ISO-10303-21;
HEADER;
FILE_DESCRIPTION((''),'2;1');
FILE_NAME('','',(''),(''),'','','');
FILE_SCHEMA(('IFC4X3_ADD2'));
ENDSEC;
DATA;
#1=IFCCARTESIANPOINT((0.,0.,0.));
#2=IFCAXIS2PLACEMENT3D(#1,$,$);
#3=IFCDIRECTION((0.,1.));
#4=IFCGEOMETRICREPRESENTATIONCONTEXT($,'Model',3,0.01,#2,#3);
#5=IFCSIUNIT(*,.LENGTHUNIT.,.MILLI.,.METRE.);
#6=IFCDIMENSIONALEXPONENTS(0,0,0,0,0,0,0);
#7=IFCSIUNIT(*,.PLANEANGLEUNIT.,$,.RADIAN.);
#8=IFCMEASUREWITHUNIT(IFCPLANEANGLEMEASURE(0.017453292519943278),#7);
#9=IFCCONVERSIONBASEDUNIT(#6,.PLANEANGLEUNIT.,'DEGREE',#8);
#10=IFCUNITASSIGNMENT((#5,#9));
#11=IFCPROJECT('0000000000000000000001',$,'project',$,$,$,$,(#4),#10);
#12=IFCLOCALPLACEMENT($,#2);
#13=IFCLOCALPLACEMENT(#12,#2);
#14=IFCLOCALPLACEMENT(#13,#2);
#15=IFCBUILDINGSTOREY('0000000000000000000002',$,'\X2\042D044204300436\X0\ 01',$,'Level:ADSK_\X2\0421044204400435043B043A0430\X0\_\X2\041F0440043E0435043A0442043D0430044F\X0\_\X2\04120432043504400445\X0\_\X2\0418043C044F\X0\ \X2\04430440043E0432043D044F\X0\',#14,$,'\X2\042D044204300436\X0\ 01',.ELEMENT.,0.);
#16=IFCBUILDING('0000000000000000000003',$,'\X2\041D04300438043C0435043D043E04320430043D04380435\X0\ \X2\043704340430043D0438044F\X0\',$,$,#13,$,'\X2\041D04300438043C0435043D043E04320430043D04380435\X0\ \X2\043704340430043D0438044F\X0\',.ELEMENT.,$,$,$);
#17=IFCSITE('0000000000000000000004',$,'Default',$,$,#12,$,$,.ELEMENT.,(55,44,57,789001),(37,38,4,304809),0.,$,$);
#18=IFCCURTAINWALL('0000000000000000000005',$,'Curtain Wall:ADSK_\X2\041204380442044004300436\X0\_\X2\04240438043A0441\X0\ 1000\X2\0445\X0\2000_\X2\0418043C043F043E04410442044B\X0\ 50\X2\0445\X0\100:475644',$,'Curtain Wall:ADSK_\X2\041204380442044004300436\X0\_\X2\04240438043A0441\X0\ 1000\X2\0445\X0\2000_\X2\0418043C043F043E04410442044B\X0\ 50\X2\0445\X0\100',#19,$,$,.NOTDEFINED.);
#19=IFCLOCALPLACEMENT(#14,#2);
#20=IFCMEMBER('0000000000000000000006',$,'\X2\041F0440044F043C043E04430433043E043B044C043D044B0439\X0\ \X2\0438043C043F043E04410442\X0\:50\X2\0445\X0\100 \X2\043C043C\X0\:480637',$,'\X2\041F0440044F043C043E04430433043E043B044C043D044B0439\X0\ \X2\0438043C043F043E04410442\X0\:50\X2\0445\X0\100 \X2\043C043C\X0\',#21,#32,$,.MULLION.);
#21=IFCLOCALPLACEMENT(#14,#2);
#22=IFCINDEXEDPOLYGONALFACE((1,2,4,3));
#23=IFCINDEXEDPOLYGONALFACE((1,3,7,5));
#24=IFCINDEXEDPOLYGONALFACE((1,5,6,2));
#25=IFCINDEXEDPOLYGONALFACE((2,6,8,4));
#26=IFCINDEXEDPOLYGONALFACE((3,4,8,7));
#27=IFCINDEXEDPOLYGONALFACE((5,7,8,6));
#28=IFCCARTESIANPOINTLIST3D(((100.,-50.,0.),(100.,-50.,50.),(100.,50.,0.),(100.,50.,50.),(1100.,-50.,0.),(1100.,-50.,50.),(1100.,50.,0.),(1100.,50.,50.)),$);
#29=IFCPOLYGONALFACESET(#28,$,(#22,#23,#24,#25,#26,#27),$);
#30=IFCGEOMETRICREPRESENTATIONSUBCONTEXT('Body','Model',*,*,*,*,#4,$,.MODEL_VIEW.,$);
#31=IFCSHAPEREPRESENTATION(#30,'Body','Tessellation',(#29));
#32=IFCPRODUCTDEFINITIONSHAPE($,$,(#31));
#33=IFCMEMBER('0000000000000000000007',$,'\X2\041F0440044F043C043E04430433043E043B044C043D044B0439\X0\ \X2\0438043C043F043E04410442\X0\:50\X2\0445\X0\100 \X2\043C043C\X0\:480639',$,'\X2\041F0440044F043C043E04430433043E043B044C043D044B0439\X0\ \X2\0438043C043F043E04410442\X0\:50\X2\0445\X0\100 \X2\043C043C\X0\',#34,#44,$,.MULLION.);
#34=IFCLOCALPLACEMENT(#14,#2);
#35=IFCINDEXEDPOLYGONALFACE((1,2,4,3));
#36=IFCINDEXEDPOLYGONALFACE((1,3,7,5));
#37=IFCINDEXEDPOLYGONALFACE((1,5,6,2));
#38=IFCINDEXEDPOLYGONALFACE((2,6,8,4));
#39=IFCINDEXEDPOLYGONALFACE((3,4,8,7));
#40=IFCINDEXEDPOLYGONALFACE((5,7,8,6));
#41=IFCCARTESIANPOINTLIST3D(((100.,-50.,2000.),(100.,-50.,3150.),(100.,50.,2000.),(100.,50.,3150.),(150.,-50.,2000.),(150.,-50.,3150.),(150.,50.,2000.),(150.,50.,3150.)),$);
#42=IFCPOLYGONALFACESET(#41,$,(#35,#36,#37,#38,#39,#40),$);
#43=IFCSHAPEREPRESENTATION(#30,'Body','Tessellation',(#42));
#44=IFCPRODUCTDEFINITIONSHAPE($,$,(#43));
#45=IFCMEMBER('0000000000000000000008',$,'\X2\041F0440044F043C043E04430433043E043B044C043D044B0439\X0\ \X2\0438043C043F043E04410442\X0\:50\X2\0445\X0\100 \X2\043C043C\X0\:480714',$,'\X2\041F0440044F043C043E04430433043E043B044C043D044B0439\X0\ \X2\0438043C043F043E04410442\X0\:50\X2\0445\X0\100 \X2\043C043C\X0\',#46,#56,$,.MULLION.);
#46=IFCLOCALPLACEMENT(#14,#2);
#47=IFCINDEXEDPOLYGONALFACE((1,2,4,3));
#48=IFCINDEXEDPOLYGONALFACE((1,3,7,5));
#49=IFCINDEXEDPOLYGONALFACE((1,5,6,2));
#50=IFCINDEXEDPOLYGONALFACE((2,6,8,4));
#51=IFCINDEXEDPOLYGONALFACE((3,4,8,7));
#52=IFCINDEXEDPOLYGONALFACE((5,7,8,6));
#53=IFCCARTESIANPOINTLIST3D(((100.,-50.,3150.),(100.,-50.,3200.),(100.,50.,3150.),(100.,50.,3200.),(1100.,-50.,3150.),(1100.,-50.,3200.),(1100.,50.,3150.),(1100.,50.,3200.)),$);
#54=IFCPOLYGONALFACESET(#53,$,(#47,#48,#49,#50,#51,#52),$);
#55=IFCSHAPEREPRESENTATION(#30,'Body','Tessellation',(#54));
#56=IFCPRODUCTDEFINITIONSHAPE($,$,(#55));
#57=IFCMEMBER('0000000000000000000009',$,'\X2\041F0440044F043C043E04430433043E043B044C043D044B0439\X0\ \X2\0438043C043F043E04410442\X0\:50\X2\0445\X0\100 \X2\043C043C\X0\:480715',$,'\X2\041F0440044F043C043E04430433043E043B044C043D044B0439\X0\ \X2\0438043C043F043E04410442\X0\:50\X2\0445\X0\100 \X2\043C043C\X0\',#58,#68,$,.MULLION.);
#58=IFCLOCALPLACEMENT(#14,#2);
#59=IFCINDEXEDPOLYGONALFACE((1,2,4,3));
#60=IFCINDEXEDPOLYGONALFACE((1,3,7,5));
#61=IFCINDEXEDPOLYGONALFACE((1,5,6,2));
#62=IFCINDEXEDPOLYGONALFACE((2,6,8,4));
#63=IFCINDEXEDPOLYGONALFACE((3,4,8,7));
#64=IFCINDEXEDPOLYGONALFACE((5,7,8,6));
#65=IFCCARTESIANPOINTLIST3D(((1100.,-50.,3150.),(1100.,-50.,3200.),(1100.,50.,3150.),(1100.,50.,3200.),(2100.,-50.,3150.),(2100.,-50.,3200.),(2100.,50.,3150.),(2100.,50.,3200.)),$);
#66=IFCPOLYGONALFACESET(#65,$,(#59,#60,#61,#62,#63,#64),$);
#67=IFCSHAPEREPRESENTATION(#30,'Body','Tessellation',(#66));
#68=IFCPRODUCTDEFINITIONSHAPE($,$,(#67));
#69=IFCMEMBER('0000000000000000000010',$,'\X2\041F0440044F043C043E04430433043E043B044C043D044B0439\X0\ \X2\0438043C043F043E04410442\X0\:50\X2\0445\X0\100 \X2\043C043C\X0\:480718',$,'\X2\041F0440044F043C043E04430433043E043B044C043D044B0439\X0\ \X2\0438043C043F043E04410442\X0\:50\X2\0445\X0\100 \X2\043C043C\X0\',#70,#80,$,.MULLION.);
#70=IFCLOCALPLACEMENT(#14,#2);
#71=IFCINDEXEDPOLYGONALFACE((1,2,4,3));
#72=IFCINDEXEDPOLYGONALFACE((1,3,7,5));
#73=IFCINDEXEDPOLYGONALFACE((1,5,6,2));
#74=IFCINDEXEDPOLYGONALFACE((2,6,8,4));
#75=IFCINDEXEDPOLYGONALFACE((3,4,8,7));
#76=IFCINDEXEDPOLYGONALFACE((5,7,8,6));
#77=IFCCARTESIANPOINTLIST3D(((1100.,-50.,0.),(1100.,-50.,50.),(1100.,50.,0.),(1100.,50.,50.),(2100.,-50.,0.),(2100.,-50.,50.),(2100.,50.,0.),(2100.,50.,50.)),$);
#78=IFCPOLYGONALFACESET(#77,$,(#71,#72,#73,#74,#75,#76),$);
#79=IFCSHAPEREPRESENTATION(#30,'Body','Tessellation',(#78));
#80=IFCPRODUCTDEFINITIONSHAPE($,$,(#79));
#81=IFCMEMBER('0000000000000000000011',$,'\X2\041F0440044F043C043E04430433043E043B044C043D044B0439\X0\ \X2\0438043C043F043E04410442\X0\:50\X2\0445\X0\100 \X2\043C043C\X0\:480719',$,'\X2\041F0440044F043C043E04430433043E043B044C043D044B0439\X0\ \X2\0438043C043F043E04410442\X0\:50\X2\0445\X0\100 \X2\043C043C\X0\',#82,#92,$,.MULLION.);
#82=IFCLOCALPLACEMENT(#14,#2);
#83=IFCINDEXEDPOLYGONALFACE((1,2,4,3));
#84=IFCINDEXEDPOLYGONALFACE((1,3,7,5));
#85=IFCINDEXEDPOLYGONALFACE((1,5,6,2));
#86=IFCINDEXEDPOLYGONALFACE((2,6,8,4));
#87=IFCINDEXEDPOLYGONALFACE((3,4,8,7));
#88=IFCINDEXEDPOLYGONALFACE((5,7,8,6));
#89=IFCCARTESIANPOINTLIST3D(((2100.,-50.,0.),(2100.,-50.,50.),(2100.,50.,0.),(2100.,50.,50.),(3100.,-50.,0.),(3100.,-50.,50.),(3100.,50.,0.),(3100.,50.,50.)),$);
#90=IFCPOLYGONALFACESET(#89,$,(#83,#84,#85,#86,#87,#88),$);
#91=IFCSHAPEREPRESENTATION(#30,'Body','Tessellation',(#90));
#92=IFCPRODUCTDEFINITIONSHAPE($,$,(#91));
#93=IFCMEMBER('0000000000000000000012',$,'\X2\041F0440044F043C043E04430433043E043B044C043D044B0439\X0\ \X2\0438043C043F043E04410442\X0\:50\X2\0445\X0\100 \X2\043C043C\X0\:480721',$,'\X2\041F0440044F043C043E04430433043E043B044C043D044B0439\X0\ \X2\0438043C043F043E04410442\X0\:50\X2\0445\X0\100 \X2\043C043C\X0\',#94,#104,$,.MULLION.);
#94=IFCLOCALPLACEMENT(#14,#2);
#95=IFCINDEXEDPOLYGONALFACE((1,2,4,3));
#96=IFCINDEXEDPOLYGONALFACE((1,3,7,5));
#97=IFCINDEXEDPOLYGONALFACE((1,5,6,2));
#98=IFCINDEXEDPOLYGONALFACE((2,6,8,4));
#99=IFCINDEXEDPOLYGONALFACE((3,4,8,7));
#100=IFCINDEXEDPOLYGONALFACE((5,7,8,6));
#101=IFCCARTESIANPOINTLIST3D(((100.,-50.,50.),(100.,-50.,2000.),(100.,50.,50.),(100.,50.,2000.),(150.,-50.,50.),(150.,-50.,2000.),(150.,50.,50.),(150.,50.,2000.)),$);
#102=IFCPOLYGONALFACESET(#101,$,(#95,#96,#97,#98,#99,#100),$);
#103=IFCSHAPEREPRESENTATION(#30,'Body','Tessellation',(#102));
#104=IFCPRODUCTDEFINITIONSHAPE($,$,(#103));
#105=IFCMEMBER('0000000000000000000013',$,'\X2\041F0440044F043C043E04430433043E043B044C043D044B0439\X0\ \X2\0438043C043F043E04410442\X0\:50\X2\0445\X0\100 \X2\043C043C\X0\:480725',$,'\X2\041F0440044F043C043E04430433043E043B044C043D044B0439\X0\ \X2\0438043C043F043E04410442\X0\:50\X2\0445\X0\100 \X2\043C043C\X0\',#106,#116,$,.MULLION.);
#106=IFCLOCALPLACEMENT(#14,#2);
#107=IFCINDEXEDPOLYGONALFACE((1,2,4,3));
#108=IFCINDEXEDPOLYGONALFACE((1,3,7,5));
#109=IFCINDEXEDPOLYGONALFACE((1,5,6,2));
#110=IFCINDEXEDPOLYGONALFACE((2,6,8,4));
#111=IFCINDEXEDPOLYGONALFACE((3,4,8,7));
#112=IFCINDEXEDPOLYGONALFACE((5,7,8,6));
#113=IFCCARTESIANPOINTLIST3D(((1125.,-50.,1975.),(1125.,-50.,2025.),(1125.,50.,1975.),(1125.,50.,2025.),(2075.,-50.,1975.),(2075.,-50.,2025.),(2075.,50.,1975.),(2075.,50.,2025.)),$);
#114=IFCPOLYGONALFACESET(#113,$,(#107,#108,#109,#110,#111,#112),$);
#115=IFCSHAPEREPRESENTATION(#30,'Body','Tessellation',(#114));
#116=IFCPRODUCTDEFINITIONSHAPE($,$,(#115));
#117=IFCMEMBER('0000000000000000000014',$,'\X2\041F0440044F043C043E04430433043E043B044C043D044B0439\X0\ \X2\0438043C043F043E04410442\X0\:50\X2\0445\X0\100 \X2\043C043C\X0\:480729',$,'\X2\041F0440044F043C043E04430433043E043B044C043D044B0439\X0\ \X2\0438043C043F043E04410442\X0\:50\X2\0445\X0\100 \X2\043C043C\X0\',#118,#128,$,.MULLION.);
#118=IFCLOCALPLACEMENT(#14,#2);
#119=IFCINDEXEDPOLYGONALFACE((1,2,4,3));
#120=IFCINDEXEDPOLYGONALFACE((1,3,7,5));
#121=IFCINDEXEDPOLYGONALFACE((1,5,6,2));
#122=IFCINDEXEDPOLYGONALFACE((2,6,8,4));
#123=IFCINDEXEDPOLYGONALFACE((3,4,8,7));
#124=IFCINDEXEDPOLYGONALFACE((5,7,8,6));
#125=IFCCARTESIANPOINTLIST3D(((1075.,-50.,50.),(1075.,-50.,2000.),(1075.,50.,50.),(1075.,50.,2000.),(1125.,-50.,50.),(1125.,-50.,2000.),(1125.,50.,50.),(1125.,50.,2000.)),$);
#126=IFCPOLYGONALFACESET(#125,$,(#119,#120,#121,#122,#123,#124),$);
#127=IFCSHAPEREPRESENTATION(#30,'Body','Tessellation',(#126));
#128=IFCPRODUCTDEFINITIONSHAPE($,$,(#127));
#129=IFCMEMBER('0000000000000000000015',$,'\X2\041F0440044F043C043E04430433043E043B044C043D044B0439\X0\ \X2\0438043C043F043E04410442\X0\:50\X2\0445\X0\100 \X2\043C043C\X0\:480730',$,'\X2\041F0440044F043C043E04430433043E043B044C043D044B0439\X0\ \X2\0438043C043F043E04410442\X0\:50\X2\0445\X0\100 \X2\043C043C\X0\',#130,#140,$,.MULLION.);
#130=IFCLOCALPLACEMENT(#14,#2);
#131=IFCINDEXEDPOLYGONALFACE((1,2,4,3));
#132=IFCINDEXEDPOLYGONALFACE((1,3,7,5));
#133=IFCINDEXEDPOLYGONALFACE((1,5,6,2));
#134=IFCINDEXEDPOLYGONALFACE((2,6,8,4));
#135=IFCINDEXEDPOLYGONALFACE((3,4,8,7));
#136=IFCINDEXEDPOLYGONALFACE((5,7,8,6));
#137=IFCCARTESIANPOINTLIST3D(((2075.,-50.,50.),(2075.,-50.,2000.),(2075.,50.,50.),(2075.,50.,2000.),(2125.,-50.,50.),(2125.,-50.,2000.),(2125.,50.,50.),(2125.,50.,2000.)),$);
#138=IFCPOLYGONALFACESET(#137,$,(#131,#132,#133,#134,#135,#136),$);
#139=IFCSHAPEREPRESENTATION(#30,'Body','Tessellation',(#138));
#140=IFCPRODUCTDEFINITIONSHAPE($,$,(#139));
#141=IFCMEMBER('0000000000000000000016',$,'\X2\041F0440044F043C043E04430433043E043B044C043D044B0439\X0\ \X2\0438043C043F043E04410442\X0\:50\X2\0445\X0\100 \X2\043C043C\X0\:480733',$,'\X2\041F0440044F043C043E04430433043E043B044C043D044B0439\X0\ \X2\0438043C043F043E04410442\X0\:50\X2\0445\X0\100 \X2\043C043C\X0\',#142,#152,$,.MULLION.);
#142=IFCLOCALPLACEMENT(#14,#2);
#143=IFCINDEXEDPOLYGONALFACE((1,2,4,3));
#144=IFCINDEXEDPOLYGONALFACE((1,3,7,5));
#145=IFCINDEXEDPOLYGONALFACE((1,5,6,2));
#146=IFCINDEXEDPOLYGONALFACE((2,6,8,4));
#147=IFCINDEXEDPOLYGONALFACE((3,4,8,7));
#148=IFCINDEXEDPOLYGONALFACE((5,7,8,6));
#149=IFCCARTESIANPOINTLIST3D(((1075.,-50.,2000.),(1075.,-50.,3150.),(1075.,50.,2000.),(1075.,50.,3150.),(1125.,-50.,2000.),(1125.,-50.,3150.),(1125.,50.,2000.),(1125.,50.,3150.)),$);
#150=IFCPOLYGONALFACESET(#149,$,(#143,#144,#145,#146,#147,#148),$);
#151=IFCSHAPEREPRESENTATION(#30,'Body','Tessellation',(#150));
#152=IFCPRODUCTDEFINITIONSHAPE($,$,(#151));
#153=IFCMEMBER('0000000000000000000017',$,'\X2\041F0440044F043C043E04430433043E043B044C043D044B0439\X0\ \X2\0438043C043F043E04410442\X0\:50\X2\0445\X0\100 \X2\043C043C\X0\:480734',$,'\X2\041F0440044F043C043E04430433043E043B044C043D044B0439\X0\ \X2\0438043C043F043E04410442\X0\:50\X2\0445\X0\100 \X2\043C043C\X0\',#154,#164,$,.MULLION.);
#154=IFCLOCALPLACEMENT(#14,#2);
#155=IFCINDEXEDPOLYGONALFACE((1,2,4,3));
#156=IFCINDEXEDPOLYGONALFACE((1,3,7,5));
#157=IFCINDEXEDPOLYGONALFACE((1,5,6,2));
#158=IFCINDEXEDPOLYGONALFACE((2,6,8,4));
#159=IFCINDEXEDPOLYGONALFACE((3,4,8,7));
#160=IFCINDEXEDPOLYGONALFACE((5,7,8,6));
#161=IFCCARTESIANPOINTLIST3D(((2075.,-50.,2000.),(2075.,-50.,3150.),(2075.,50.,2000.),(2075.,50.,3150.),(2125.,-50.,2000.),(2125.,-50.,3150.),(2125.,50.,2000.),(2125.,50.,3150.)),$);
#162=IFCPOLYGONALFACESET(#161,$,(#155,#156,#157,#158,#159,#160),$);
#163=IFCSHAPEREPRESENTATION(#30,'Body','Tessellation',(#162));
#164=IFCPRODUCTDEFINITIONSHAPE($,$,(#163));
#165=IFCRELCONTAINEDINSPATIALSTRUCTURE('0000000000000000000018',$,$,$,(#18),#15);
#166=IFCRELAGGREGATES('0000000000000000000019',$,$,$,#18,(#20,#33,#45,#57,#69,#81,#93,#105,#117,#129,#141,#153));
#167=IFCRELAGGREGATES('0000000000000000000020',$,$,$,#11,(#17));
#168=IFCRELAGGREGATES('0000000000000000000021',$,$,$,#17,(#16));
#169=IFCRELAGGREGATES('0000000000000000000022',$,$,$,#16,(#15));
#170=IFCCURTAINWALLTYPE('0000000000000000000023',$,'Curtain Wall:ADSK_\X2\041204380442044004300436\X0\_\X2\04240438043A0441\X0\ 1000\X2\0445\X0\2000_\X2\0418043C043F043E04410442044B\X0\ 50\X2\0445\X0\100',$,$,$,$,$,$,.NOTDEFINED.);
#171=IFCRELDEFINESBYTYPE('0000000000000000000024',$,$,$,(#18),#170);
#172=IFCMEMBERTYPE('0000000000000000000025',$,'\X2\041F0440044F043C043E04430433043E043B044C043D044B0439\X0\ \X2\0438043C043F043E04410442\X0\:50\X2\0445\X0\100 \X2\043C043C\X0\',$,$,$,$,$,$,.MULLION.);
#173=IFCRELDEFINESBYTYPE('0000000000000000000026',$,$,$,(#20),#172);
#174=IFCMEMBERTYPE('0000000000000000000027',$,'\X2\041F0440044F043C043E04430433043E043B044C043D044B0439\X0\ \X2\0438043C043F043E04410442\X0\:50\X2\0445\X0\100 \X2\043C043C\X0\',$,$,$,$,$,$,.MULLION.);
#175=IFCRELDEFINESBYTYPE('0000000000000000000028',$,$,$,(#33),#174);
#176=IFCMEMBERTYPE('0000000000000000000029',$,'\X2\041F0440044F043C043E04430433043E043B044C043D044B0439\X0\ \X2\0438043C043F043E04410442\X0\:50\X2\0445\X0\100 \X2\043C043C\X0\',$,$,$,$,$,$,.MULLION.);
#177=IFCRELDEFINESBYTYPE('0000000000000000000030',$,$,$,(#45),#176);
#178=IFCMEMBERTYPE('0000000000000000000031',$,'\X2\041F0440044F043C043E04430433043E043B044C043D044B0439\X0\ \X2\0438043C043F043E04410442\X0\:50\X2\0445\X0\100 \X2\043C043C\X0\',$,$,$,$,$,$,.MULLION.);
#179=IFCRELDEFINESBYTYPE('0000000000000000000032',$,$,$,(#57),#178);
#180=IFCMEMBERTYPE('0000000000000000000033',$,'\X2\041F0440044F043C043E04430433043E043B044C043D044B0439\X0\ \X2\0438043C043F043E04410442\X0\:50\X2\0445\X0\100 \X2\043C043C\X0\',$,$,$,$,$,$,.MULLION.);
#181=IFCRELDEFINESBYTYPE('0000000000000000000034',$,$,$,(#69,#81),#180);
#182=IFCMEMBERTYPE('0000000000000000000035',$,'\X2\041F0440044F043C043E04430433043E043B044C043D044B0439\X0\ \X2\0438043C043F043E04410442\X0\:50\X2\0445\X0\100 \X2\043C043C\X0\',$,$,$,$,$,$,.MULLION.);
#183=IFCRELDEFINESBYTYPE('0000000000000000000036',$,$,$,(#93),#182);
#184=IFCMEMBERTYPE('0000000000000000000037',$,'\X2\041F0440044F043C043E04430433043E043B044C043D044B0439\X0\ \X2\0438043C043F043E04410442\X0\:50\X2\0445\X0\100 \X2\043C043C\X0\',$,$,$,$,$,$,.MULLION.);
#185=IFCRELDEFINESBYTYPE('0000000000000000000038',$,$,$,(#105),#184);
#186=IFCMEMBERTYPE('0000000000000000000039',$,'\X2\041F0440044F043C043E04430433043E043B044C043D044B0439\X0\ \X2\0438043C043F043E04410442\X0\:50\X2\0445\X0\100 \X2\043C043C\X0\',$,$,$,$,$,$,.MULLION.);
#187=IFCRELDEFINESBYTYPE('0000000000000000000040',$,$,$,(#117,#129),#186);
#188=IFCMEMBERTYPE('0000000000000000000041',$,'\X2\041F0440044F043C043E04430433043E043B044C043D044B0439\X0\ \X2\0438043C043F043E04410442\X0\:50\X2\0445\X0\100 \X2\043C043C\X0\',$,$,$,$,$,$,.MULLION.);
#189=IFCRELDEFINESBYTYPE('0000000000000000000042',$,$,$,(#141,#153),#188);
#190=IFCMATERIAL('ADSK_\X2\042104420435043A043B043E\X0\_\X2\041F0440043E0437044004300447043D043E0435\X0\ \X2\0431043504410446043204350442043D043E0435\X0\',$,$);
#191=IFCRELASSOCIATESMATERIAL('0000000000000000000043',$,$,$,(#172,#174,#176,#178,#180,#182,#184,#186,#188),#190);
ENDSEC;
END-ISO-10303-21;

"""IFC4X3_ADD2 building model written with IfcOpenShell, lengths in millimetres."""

from ifc_helpers import new_model, entity, si_unit, converted_unit, direction, frame, frame_2d, origin, place, context, subcontext, project, spatial, rectangle, extrude, source, transform, mapped, material, material_profile, profile_set, type_object, type_shapes, element, aggregate, save


model = new_model("IFC4X3_ADD2")

# Units and contexts
model_context = context("Model", 3, precision=0.01, world=origin(), true_north=direction((0.0, 1.0)))
body_context = subcontext(model_context, "Body", "Model", "MODEL_VIEW")
ifc_project = project(units=[si_unit("LENGTHUNIT", "METRE", prefix="MILLI"), converted_unit("PLANEANGLEUNIT", "DEGREE", entity("IfcPlaneAngleMeasure", 0.017453292519943278), si_unit("PLANEANGLEUNIT", "RADIAN"), dimensions=[0, 0, 0, 0, 0, 0, 0])], contexts=[model_context])

# Site, building, storey
site_placement = place(None, origin())
site = spatial("IfcSite", under=ifc_project, at=site_placement, Name="Default", CompositionType="ELEMENT", RefLatitude=(55, 44, 57, 789001), RefLongitude=(37, 38, 4, 304809), RefElevation=0.0)
building_placement = place(site_placement, origin())
building = spatial("IfcBuilding", under=site, at=building_placement, Name="Наименование здания", LongName="Наименование здания", CompositionType="ELEMENT")
storey_placement = place(building_placement, origin())
storey = spatial("IfcBuildingStorey", under=building, at=storey_placement, Name="Этаж 01", ObjectType="Level:ADSK_Стрелка_Проектная_Вверх_Имя уровня", LongName="Этаж 01", CompositionType="ELEMENT", Elevation=0.0)

# Curtain wall, members
curtain_wall_type = type_object("IfcCurtainWallType", Name="Curtain Wall:ADSK_Витраж_Фикс 1000х2000_Импосты 50х100", PredefinedType="NOTDEFINED")
curtain_wall_1_placement = place(storey_placement, origin())
curtain_wall_1 = element("IfcCurtainWall", 1, at=curtain_wall_1_placement, inside=storey, type_object=curtain_wall_type, Name="Curtain Wall:ADSK_Витраж_Фикс 1000х2000_Импосты 50х100:475644", ObjectType="Curtain Wall:ADSK_Витраж_Фикс 1000х2000_Импосты 50х100", PredefinedType="NOTDEFINED")
ifc_material_1 = material(Name="ADSK_Стекло_Прозрачное бесцветное")
ifc_material_profile = material_profile(ifc_material_1, rectangle(XDim=50.0, YDim=100.0, at=frame_2d((0.0, 0.0), x_axis=(1.0, 0.0))), Name="50х100 мм")
ifc_profile_set = profile_set([ifc_material_profile], Name="50х100 мм")
member_type_1 = type_object("IfcMemberType", Name="Прямоугольный импост:50х100 мм", PredefinedType="MULLION", material=ifc_profile_set)
shared_shape_1 = source(origin(), body_context, "Body", "SweptSolid", [
    extrude(rectangle(XDim=50.0, YDim=100.0, at=frame_2d((0.0, 0.0), x_axis=(1.0, 0.0))), frame((-25.0, 0.0, -1000.0), z_axis=(0.0, 0.0, 1.0), x_axis=(-1.0, 0.0, 0.0)), (0.0, 0.0, 1.0), 1000.0),
])
type_shapes(member_type_1, [shared_shape_1])
member_1_placement = place(curtain_wall_1_placement, frame((100.0, 0.0, 0.0), z_axis=(-1.0, 0.0, 0.0), x_axis=(0.0, 0.0, -1.0)))
member_1 = element("IfcMember", 2, at=member_1_placement, type_object=member_type_1, Name="Прямоугольный импост:50х100 мм:480637", ObjectType="Прямоугольный импост:50х100 мм", PredefinedType="MULLION", context=body_context, shape_type="MappedRepresentation", body=[
    mapped(shared_shape_1, transform((0.0, 0.0, 0.0), scale=1.0)),
])
member_type_2 = type_object("IfcMemberType", Name="Прямоугольный импост:50х100 мм", PredefinedType="MULLION", material=ifc_profile_set)
shared_shape_2 = source(origin(), body_context, "Body", "SweptSolid", [
    extrude(rectangle(XDim=50.0, YDim=100.0, at=frame_2d((0.0, 0.0), x_axis=(1.0, 0.0))), frame((-25.0, 0.0, -1150.0), z_axis=(0.0, 0.0, 1.0), x_axis=(-1.0, 0.0, 0.0)), (0.0, 0.0, 1.0), 1150.0),
])
type_shapes(member_type_2, [shared_shape_2])
member_2_placement = place(curtain_wall_1_placement, frame((100.0, 0.0, 3150.0), z_axis=(0.0, 0.0, 1.0), x_axis=(-1.0, 0.0, 0.0)))
member_2 = element("IfcMember", 3, at=member_2_placement, type_object=member_type_2, Name="Прямоугольный импост:50х100 мм:480639", ObjectType="Прямоугольный импост:50х100 мм", PredefinedType="MULLION", context=body_context, shape_type="MappedRepresentation", body=[
    mapped(shared_shape_2, transform((0.0, 0.0, 0.0), scale=1.0)),
])
member_type_3 = type_object("IfcMemberType", Name="Прямоугольный импост:50х100 мм", PredefinedType="MULLION", material=ifc_profile_set)
shared_shape_3 = source(origin(), body_context, "Body", "SweptSolid", [
    extrude(rectangle(XDim=50.0, YDim=100.0, at=frame_2d((0.0, 0.0), x_axis=(1.0, 0.0))), frame((-25.0, 0.0, -1000.0), z_axis=(0.0, 0.0, 1.0), x_axis=(-1.0, 0.0, 0.0)), (0.0, 0.0, 1.0), 1000.0),
])
type_shapes(member_type_3, [shared_shape_3])
member_3_placement = place(curtain_wall_1_placement, frame((1100.0, 0.0, 3200.0), z_axis=(1.0, 0.0, 0.0), x_axis=(0.0, 0.0, 1.0)))
member_3 = element("IfcMember", 4, at=member_3_placement, type_object=member_type_3, Name="Прямоугольный импост:50х100 мм:480714", ObjectType="Прямоугольный импост:50х100 мм", PredefinedType="MULLION", context=body_context, shape_type="MappedRepresentation", body=[
    mapped(shared_shape_3, transform((0.0, 0.0, 0.0), scale=1.0)),
])
member_type_4 = type_object("IfcMemberType", Name="Прямоугольный импост:50х100 мм", PredefinedType="MULLION", material=ifc_profile_set)
shared_shape_4 = source(origin(), body_context, "Body", "SweptSolid", [
    extrude(rectangle(XDim=50.0, YDim=100.0, at=frame_2d((0.0, 0.0), x_axis=(1.0, 0.0))), frame((-25.0, 0.0, -1000.0), z_axis=(0.0, 0.0, 1.0), x_axis=(-1.0, 0.0, 0.0)), (0.0, 0.0, 1.0), 1000.0),
])
type_shapes(member_type_4, [shared_shape_4])
member_4_placement = place(curtain_wall_1_placement, frame((2100.0, 0.0, 3200.0), z_axis=(1.0, 0.0, 0.0), x_axis=(0.0, 0.0, 1.0)))
member_4 = element("IfcMember", 5, at=member_4_placement, type_object=member_type_4, Name="Прямоугольный импост:50х100 мм:480715", ObjectType="Прямоугольный импост:50х100 мм", PredefinedType="MULLION", context=body_context, shape_type="MappedRepresentation", body=[
    mapped(shared_shape_4, transform((0.0, 0.0, 0.0), scale=1.0)),
])
member_type_5 = type_object("IfcMemberType", Name="Прямоугольный импост:50х100 мм", PredefinedType="MULLION", material=ifc_profile_set)
shared_shape_5 = source(origin(), body_context, "Body", "SweptSolid", [
    extrude(rectangle(XDim=50.0, YDim=100.0, at=frame_2d((0.0, 0.0), x_axis=(1.0, 0.0))), frame((-25.0, 0.0, -1000.0), z_axis=(0.0, 0.0, 1.0), x_axis=(-1.0, 0.0, 0.0)), (0.0, 0.0, 1.0), 1000.0),
])
type_shapes(member_type_5, [shared_shape_5])
member_5_placement = place(curtain_wall_1_placement, frame((1100.0, 0.0, 0.0), z_axis=(-1.0, 0.0, 0.0), x_axis=(0.0, 0.0, -1.0)))
member_5 = element("IfcMember", 6, at=member_5_placement, type_object=member_type_5, Name="Прямоугольный импост:50х100 мм:480718", ObjectType="Прямоугольный импост:50х100 мм", PredefinedType="MULLION", context=body_context, shape_type="MappedRepresentation", body=[
    mapped(shared_shape_5, transform((0.0, 0.0, 0.0), scale=1.0)),
])
member_6_placement = place(curtain_wall_1_placement, frame((2100.0, 0.0, 0.0), z_axis=(-1.0, 0.0, 0.0), x_axis=(0.0, 0.0, -1.0)))
member_6 = element("IfcMember", 7, at=member_6_placement, type_object=member_type_5, Name="Прямоугольный импост:50х100 мм:480719", ObjectType="Прямоугольный импост:50х100 мм", PredefinedType="MULLION", context=body_context, shape_type="MappedRepresentation", body=[
    mapped(shared_shape_5, transform((0.0, 0.0, 0.0), scale=1.0)),
])
member_type_6 = type_object("IfcMemberType", Name="Прямоугольный импост:50х100 мм", PredefinedType="MULLION", material=ifc_profile_set)
shared_shape_6 = source(origin(), body_context, "Body", "SweptSolid", [
    extrude(rectangle(XDim=50.0, YDim=100.0, at=frame_2d((0.0, 0.0), x_axis=(1.0, 0.0))), frame((-25.0, 0.0, -1950.0), z_axis=(0.0, 0.0, 1.0), x_axis=(-1.0, 0.0, 0.0)), (0.0, 0.0, 1.0), 1950.0),
])
type_shapes(member_type_6, [shared_shape_6])
member_7_placement = place(curtain_wall_1_placement, frame((100.0, 0.0, 2000.0), z_axis=(0.0, 0.0, 1.0), x_axis=(-1.0, 0.0, 0.0)))
member_7 = element("IfcMember", 8, at=member_7_placement, type_object=member_type_6, Name="Прямоугольный импост:50х100 мм:480721", ObjectType="Прямоугольный импост:50х100 мм", PredefinedType="MULLION", context=body_context, shape_type="MappedRepresentation", body=[
    mapped(shared_shape_6, transform((0.0, 0.0, 0.0), scale=1.0)),
])
member_type_7 = type_object("IfcMemberType", Name="Прямоугольный импост:50х100 мм", PredefinedType="MULLION", material=ifc_profile_set)
shared_shape_7 = source(origin(), body_context, "Body", "SweptSolid", [
    extrude(rectangle(XDim=50.0, YDim=100.0, at=frame_2d((0.0, 0.0), x_axis=(1.0, 0.0))), frame((0.0, 0.0, -950.0), z_axis=(0.0, 0.0, 1.0), x_axis=(-1.0, 0.0, 0.0)), (0.0, 0.0, 1.0), 950.0),
])
type_shapes(member_type_7, [shared_shape_7])
member_8_placement = place(curtain_wall_1_placement, frame((2075.0, 0.0, 2000.0), z_axis=(1.0, 0.0, 0.0), x_axis=(0.0, 0.0, 1.0)))
member_8 = element("IfcMember", 9, at=member_8_placement, type_object=member_type_7, Name="Прямоугольный импост:50х100 мм:480725", ObjectType="Прямоугольный импост:50х100 мм", PredefinedType="MULLION", context=body_context, shape_type="MappedRepresentation", body=[
    mapped(shared_shape_7, transform((0.0, 0.0, 0.0), scale=1.0)),
])
member_type_8 = type_object("IfcMemberType", Name="Прямоугольный импост:50х100 мм", PredefinedType="MULLION", material=ifc_profile_set)
shared_shape_8 = source(origin(), body_context, "Body", "SweptSolid", [
    extrude(rectangle(XDim=50.0, YDim=100.0, at=frame_2d((0.0, 0.0), x_axis=(1.0, 0.0))), frame((0.0, 0.0, -1950.0), z_axis=(0.0, 0.0, 1.0), x_axis=(-1.0, 0.0, 0.0)), (0.0, 0.0, 1.0), 1950.0),
])
type_shapes(member_type_8, [shared_shape_8])
member_9_placement = place(curtain_wall_1_placement, frame((1100.0, 0.0, 50.0), z_axis=(0.0, 0.0, -1.0), x_axis=(1.0, 0.0, 0.0)))
member_9 = element("IfcMember", 10, at=member_9_placement, type_object=member_type_8, Name="Прямоугольный импост:50х100 мм:480729", ObjectType="Прямоугольный импост:50х100 мм", PredefinedType="MULLION", context=body_context, shape_type="MappedRepresentation", body=[
    mapped(shared_shape_8, transform((0.0, 0.0, 0.0), scale=1.0)),
])
member_10_placement = place(curtain_wall_1_placement, frame((2100.0, 0.0, 50.0), z_axis=(0.0, 0.0, -1.0), x_axis=(1.0, 0.0, 0.0)))
member_10 = element("IfcMember", 11, at=member_10_placement, type_object=member_type_8, Name="Прямоугольный импост:50х100 мм:480730", ObjectType="Прямоугольный импост:50х100 мм", PredefinedType="MULLION", context=body_context, shape_type="MappedRepresentation", body=[
    mapped(shared_shape_8, transform((0.0, 0.0, 0.0), scale=1.0)),
])
member_type_9 = type_object("IfcMemberType", Name="Прямоугольный импост:50х100 мм", PredefinedType="MULLION", material=ifc_profile_set)
shared_shape_9 = source(origin(), body_context, "Body", "SweptSolid", [
    extrude(rectangle(XDim=50.0, YDim=100.0, at=frame_2d((0.0, 0.0), x_axis=(1.0, 0.0))), frame((0.0, 0.0, -1150.0), z_axis=(0.0, 0.0, 1.0), x_axis=(-1.0, 0.0, 0.0)), (0.0, 0.0, 1.0), 1150.0),
])
type_shapes(member_type_9, [shared_shape_9])
member_11_placement = place(curtain_wall_1_placement, frame((1100.0, 0.0, 2000.0), z_axis=(0.0, 0.0, -1.0), x_axis=(1.0, 0.0, 0.0)))
member_11 = element("IfcMember", 12, at=member_11_placement, type_object=member_type_9, Name="Прямоугольный импост:50х100 мм:480733", ObjectType="Прямоугольный импост:50х100 мм", PredefinedType="MULLION", context=body_context, shape_type="MappedRepresentation", body=[
    mapped(shared_shape_9, transform((0.0, 0.0, 0.0), scale=1.0)),
])
member_12_placement = place(curtain_wall_1_placement, frame((2100.0, 0.0, 2000.0), z_axis=(0.0, 0.0, -1.0), x_axis=(1.0, 0.0, 0.0)))
member_12 = element("IfcMember", 13, at=member_12_placement, type_object=member_type_9, Name="Прямоугольный импост:50х100 мм:480734", ObjectType="Прямоугольный импост:50х100 мм", PredefinedType="MULLION", context=body_context, shape_type="MappedRepresentation", body=[
    mapped(shared_shape_9, transform((0.0, 0.0, 0.0), scale=1.0)),
])

aggregate(curtain_wall_1, [member_1, member_2, member_3, member_4, member_5, member_6, member_7, member_8, member_9, member_10, member_11, member_12])

save(model, "model.ifc")
